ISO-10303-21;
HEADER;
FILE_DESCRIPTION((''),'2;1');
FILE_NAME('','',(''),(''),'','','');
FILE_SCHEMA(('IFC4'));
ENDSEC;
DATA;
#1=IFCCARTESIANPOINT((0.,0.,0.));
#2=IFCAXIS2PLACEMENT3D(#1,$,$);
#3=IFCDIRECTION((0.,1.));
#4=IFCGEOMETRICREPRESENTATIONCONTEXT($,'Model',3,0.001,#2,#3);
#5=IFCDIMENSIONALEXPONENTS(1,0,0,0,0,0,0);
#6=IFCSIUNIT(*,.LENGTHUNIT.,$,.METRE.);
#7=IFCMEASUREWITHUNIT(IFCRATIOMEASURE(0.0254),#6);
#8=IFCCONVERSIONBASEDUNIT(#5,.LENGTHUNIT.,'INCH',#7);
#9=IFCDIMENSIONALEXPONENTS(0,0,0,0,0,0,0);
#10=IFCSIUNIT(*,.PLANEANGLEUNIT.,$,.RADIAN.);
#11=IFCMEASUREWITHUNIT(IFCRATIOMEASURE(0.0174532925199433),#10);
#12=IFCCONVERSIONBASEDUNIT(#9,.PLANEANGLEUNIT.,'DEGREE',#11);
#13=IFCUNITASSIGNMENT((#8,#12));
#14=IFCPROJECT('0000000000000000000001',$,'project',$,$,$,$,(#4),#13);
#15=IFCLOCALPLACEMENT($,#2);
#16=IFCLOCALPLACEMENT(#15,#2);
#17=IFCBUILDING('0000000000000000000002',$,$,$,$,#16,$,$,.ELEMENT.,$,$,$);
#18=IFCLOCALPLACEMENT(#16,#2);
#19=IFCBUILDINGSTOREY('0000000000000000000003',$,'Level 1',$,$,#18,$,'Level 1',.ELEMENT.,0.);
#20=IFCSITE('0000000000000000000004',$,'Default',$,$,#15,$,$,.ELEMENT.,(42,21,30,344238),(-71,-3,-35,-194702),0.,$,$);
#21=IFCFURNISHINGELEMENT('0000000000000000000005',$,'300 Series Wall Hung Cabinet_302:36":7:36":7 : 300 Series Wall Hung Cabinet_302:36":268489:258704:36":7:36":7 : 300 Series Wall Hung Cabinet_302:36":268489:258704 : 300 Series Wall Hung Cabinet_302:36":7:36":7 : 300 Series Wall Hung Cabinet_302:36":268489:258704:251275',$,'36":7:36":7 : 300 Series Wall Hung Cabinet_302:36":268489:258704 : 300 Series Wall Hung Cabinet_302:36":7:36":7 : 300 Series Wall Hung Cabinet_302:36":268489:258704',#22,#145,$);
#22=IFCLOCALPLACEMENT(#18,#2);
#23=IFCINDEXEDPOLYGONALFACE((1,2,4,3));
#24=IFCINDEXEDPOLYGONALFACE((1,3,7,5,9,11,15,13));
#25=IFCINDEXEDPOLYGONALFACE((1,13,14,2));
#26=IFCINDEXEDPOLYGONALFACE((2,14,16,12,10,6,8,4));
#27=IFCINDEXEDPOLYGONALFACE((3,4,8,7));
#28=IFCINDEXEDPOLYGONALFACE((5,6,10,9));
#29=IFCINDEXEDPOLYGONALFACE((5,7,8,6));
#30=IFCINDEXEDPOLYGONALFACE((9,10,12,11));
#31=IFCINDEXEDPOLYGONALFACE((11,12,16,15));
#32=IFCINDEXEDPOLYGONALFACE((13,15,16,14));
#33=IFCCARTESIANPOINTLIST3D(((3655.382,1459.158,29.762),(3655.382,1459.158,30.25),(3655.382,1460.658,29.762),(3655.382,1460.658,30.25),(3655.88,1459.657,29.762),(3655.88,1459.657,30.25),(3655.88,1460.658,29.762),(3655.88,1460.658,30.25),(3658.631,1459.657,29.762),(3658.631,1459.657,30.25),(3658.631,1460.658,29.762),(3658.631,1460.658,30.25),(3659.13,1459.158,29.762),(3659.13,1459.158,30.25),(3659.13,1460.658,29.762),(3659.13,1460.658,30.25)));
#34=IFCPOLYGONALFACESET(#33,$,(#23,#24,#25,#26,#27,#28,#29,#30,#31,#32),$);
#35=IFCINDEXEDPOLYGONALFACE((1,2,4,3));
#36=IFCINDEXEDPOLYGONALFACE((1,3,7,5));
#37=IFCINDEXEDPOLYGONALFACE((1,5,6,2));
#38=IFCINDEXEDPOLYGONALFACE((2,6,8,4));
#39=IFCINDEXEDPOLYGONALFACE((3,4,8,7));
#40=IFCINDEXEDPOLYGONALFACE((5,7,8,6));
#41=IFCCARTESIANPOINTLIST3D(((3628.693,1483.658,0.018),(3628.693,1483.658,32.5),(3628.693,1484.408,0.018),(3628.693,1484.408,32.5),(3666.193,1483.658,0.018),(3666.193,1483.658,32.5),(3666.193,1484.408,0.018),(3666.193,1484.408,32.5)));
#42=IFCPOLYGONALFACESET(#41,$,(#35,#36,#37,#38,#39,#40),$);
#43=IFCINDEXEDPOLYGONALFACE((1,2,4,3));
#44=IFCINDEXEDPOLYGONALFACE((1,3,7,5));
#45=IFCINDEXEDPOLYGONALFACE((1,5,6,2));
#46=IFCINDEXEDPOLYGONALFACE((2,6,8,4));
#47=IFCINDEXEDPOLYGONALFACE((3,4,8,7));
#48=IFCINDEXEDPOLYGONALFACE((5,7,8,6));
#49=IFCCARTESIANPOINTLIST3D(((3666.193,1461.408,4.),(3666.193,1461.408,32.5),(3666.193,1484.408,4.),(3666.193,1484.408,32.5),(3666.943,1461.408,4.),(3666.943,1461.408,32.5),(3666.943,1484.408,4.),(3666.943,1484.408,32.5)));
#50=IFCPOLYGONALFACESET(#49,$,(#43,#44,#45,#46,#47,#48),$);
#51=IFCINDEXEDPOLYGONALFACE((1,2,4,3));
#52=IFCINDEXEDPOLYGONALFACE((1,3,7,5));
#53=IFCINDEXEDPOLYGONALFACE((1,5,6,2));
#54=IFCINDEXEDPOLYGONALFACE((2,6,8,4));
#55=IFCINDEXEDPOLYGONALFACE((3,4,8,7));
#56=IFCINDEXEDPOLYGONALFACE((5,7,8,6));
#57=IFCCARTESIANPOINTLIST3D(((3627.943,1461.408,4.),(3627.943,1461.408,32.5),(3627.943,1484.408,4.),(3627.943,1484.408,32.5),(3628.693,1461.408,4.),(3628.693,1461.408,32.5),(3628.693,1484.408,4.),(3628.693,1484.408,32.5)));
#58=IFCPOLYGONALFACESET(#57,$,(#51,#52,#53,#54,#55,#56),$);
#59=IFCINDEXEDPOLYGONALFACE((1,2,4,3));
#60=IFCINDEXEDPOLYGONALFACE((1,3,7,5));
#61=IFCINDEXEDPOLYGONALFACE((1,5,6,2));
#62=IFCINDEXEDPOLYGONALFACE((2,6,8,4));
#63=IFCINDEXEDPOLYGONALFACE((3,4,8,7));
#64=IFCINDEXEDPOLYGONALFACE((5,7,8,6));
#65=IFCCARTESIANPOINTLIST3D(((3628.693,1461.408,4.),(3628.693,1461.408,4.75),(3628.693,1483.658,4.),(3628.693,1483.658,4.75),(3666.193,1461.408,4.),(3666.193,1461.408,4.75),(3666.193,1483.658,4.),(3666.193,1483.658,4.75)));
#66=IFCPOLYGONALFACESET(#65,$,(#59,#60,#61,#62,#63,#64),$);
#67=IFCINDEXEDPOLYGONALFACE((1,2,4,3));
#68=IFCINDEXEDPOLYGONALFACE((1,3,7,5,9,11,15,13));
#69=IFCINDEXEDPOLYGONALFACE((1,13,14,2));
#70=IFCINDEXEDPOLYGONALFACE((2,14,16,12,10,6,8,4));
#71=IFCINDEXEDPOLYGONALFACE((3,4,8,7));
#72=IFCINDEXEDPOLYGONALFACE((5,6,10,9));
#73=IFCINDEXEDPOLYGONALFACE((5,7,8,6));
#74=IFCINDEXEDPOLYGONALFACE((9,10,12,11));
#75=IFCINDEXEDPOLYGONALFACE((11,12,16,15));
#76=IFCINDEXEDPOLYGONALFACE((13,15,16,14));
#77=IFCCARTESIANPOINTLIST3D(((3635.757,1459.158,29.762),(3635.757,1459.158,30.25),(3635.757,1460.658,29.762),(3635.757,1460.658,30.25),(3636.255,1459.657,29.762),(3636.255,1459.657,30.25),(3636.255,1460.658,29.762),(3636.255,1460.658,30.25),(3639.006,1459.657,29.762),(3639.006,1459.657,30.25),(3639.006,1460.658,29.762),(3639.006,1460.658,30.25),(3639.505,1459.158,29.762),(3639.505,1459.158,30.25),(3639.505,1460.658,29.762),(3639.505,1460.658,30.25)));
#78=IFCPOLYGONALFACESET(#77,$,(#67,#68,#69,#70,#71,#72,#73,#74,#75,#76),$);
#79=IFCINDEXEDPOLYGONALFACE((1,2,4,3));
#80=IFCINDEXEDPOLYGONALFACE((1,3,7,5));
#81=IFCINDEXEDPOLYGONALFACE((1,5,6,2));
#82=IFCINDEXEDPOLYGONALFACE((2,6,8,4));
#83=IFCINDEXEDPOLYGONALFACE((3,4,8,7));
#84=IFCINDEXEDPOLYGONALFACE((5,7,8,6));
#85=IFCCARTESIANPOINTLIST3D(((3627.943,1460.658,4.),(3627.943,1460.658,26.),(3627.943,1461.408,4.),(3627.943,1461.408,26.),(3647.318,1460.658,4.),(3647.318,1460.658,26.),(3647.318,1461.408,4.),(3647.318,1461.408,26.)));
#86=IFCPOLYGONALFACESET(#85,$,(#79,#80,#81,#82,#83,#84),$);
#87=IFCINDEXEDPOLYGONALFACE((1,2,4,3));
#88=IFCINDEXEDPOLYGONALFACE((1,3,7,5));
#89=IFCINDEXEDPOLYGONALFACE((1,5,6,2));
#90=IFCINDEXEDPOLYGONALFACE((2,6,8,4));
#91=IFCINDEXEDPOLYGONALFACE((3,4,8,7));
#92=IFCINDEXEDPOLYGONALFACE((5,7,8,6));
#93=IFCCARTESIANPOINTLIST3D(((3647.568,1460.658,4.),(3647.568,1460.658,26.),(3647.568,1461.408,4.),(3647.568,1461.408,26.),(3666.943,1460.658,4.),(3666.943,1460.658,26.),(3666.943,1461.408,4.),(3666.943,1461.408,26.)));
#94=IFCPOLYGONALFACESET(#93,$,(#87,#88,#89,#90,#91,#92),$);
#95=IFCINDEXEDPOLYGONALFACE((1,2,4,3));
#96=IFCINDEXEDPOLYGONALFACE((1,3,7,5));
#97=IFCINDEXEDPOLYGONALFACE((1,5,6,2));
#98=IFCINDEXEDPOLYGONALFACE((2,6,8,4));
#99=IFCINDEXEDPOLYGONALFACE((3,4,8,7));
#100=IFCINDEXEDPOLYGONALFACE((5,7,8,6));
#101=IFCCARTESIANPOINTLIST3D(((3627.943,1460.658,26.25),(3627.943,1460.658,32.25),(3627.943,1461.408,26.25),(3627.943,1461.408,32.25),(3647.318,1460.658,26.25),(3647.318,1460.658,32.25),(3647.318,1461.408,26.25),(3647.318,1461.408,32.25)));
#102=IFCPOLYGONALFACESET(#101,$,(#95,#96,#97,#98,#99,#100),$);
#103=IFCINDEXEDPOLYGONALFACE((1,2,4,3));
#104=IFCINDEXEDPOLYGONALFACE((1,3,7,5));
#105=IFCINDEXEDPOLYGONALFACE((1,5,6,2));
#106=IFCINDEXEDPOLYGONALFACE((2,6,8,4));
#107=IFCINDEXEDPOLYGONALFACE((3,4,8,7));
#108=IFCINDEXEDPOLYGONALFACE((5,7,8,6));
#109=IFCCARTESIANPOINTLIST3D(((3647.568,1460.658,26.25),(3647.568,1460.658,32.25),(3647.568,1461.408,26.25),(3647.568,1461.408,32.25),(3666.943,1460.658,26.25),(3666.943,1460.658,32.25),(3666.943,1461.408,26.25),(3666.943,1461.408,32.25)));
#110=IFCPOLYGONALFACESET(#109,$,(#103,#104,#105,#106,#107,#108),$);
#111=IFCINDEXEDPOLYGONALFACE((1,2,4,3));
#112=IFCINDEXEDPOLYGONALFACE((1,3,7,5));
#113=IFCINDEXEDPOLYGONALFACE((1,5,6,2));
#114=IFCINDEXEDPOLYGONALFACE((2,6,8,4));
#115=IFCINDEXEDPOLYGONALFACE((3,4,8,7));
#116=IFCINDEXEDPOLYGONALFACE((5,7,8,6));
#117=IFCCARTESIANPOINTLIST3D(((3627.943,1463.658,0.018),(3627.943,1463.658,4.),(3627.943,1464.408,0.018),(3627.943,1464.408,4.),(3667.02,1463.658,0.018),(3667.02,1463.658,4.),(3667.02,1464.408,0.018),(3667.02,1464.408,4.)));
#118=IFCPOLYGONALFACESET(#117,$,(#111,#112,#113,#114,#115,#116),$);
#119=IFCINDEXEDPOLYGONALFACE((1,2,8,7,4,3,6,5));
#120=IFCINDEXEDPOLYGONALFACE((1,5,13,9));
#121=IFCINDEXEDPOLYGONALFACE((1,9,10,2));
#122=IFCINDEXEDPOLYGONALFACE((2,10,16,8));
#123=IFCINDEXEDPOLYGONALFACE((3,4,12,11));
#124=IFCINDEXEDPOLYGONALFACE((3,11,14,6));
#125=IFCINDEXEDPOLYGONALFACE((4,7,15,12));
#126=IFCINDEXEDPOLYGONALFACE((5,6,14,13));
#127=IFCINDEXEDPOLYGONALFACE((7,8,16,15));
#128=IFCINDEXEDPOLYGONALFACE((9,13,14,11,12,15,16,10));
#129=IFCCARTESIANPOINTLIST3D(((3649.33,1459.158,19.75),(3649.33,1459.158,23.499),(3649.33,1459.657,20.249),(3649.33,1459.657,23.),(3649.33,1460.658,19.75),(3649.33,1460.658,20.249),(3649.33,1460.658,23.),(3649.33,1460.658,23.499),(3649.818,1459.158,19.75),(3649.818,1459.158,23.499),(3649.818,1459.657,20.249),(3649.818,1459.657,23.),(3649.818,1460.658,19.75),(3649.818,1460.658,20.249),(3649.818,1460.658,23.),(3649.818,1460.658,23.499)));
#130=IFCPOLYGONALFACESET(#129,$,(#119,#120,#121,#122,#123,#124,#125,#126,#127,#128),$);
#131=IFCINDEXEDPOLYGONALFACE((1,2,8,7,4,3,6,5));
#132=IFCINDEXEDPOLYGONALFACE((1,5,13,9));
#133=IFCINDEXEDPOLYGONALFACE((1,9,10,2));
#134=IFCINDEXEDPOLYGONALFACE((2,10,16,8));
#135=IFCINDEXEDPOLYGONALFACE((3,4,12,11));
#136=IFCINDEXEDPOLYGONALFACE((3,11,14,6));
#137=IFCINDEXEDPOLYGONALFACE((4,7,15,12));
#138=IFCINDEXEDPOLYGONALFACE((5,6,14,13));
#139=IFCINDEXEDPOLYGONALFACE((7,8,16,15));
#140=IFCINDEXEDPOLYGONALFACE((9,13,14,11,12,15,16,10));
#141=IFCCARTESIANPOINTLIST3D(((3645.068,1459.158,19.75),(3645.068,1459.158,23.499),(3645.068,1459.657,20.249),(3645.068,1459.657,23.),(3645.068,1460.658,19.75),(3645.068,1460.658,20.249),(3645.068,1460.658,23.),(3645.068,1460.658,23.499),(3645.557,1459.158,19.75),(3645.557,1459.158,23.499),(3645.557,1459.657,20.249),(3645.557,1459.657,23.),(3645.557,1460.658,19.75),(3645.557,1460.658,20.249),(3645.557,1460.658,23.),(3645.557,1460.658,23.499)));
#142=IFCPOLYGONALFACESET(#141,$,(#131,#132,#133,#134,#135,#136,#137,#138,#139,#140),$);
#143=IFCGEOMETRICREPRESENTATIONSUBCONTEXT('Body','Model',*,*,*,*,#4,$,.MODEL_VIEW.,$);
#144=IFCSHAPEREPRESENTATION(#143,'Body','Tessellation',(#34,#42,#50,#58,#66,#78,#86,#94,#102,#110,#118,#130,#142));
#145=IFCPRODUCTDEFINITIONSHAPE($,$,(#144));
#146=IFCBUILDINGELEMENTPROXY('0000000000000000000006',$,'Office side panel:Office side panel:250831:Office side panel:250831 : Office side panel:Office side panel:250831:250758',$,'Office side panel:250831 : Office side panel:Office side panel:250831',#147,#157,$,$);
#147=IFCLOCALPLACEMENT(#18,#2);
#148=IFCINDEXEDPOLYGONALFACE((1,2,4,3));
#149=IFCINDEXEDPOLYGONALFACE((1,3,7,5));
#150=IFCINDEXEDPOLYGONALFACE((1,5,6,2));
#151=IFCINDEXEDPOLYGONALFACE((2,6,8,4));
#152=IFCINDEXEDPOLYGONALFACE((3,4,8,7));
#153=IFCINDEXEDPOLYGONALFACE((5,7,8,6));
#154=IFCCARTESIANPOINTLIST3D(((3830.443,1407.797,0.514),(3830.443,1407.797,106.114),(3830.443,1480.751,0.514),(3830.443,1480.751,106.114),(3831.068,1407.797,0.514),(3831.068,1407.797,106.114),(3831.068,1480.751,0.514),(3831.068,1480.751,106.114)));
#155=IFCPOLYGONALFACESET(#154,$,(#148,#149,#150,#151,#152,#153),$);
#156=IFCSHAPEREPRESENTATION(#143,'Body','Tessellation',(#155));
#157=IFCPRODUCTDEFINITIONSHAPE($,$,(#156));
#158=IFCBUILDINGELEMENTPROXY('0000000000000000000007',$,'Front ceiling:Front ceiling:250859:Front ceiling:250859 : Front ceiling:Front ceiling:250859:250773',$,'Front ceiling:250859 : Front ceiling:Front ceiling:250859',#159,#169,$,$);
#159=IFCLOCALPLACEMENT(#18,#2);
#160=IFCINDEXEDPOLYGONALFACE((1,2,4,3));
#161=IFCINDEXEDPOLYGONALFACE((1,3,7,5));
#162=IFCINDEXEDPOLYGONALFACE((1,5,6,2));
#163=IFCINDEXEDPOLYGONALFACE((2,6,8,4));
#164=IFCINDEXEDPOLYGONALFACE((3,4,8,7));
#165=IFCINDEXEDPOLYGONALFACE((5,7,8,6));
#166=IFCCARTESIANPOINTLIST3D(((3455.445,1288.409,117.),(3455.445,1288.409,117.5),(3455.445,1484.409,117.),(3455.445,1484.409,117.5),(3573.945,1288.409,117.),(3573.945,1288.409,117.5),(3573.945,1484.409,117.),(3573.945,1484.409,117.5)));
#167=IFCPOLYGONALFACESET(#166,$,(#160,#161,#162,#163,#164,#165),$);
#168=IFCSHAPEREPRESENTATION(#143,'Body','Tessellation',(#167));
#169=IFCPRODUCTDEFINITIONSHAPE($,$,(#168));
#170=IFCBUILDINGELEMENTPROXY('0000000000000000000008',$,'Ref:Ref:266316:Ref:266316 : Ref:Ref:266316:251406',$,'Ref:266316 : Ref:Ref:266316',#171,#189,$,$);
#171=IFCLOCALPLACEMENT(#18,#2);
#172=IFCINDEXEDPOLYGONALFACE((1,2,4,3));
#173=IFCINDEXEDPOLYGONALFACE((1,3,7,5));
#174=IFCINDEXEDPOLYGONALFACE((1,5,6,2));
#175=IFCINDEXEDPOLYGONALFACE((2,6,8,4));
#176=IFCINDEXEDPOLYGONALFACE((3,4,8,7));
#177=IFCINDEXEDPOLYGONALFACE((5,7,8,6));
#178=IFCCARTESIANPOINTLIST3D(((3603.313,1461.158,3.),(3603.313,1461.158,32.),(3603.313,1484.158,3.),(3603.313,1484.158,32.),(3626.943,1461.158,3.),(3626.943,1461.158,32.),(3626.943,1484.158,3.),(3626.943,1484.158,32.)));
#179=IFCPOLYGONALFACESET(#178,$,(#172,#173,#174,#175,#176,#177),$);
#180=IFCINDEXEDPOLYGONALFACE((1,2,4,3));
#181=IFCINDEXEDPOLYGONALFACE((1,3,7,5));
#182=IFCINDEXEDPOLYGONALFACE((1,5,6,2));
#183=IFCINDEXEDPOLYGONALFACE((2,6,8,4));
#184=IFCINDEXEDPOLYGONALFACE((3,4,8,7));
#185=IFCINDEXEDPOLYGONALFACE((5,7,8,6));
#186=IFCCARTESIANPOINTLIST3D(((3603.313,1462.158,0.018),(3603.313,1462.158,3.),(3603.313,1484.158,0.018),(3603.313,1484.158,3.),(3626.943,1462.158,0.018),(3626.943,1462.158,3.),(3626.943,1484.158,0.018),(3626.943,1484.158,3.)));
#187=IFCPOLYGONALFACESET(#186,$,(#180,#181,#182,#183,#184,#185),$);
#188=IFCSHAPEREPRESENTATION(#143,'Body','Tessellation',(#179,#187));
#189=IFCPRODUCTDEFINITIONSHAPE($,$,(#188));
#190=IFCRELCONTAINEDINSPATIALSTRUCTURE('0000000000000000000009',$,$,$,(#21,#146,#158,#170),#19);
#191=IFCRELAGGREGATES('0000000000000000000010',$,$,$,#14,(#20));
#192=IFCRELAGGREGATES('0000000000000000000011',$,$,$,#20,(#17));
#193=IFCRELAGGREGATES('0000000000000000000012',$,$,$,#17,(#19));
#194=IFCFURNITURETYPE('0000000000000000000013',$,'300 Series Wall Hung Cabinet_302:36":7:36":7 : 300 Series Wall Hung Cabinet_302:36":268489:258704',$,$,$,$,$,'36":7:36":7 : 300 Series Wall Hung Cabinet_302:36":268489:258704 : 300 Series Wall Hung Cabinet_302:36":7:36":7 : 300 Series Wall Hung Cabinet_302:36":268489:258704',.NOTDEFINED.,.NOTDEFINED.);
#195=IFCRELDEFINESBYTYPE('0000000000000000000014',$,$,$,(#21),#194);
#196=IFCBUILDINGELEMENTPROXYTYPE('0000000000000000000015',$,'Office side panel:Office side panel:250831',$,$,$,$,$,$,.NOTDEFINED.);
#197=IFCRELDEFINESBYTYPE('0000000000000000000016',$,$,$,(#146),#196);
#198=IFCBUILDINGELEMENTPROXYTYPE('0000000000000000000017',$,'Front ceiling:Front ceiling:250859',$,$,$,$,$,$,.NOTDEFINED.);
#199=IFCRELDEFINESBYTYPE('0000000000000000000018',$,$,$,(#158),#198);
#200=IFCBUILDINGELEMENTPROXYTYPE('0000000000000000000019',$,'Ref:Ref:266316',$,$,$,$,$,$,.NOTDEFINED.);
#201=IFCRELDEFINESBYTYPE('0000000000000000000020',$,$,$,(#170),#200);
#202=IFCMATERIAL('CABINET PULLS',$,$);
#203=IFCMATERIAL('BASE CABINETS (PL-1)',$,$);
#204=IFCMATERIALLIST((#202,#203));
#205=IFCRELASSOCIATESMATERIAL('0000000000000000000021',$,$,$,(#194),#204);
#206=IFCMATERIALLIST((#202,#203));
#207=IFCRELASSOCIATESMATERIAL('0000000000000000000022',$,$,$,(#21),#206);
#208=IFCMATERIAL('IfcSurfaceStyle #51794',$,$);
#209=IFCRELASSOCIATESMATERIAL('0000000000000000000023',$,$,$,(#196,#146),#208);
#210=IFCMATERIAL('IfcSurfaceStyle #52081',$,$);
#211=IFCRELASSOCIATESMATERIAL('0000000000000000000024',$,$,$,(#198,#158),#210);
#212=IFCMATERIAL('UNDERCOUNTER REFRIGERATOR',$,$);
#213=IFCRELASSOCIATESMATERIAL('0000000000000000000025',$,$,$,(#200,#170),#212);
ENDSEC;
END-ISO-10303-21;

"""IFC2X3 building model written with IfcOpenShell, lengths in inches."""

from ifc_helpers import new_model, entity, si_unit, converted_unit, direction, frame, frame_2d, origin, origin_2d_with_axis, place, context, subcontext, project, spatial, polyline, rectangle, outline, extrude, source, transform, mapped, material, material_list, type_object, type_shapes, element, save


model = new_model("IFC2X3")

# Units and contexts
model_context = context("Model", 3, precision=0.001, world=origin(), true_north=direction((0.0, 1.0)))
body_context = subcontext(model_context, "Body", "Model", "MODEL_VIEW")
ifc_project = project(units=[converted_unit("LENGTHUNIT", "INCH", entity("IfcRatioMeasure", 0.0254), si_unit("LENGTHUNIT", "METRE"), dimensions=[1, 0, 0, 0, 0, 0, 0]), converted_unit("PLANEANGLEUNIT", "DEGREE", entity("IfcRatioMeasure", 0.0174532925199433), si_unit("PLANEANGLEUNIT", "RADIAN"), dimensions=[0, 0, 0, 0, 0, 0, 0])], contexts=[model_context])

# Site, building, storey
site_placement = place(None, origin())
site = spatial("IfcSite", under=ifc_project, at=site_placement, Name="Default", CompositionType="ELEMENT", RefLatitude=(42, 21, 30, 344238), RefLongitude=(-71, -3, -35, -194702), RefElevation=0.0)
building_placement = place(site_placement, origin())
building = spatial("IfcBuilding", under=site, at=building_placement, CompositionType="ELEMENT")
storey_placement = place(building_placement, origin())
storey = spatial("IfcBuildingStorey", under=building, at=storey_placement, Name="Level 1", LongName="Level 1", CompositionType="ELEMENT", Elevation=0.0)

# Furnishing element
ifc_material_1 = material(Name="CABINET PULLS")
ifc_material_2 = material(Name="BASE CABINETS (PL-1)")
ifc_material_list_1 = material_list([ifc_material_1, ifc_material_2])
ifc_material_list_2 = material_list([ifc_material_1, ifc_material_2])
furniture_type_1 = type_object("IfcFurnitureType", Name="300 Series Wall Hung Cabinet_302:36\":7:36\":7 : 300 Series Wall Hung Cabinet_302:36\":268489:258704", ElementType="36\":7:36\":7 : 300 Series Wall Hung Cabinet_302:36\":268489:258704 : 300 Series Wall Hung Cabinet_302:36\":7:36\":7 : 300 Series Wall Hung Cabinet_302:36\":268489:258704", AssemblyPlace="NOTDEFINED", material=ifc_material_list_2)
shared_shape_1 = source(origin(), body_context, "Body", "SweptSolid", [
    extrude(outline(polyline([(-0.376, 1.375), (0.625, 1.375), (0.625, 1.874), (-0.874, 1.874), (-0.874, -1.874), (0.625, -1.874), (0.625, -1.375), (-0.376, -1.375), (-0.376, 1.375)])), frame((3657.256, 1460.033, 29.762), z_axis=(0.0, 0.0, 1.0), x_axis=(0.0, 1.0, 0.0)), (0.0, 0.0, 1.0), 0.488),
    extrude(rectangle(XDim=0.75, YDim=37.5, at=origin_2d_with_axis()), frame((3647.443, 1484.033, 0.018), z_axis=(0.0, 0.0, 1.0), x_axis=(0.0, 1.0, 0.0)), (0.0, 0.0, 1.0), 32.482),
    extrude(rectangle(XDim=0.75, YDim=23.0, at=frame_2d((0.0, 0.0), x_axis=(1.0, 0.0))), frame((3666.568, 1472.908, 4.0)), (0.0, 0.0, 1.0), 28.5),
    extrude(rectangle(XDim=0.75, YDim=23.0, at=frame_2d((0.0, 0.0), x_axis=(1.0, 0.0))), frame((3628.318, 1472.908, 4.0)), (0.0, 0.0, 1.0), 28.5),
    extrude(rectangle(XDim=37.5, YDim=22.25, at=frame_2d((0.0, 0.0), x_axis=(1.0, 0.0))), frame((3647.443, 1472.533, 4.0), z_axis=(0.0, 0.0, 1.0), x_axis=(-1.0, 0.0, 0.0)), (0.0, 0.0, 1.0), 0.75),
    extrude(outline(polyline([(-0.376, 1.375), (0.625, 1.375), (0.625, 1.874), (-0.874, 1.874), (-0.874, -1.874), (0.625, -1.874), (0.625, -1.375), (-0.376, -1.375), (-0.376, 1.375)])), frame((3637.631, 1460.033, 29.762), z_axis=(0.0, 0.0, 1.0), x_axis=(0.0, 1.0, 0.0)), (0.0, 0.0, 1.0), 0.488),
    extrude(rectangle(XDim=19.375, YDim=0.75, at=frame_2d((0.0, 0.0), x_axis=(1.0, 0.0))), frame((3637.631, 1461.033, 4.0), z_axis=(0.0, 0.0, 1.0), x_axis=(-1.0, 0.0, 0.0)), (0.0, 0.0, 1.0), 22.0),
    extrude(rectangle(XDim=19.375, YDim=0.75, at=frame_2d((0.0, 0.0), x_axis=(1.0, 0.0))), frame((3657.256, 1461.033, 4.0), z_axis=(0.0, 0.0, 1.0), x_axis=(-1.0, 0.0, 0.0)), (0.0, 0.0, 1.0), 22.0),
    extrude(rectangle(XDim=19.375, YDim=0.75, at=frame_2d((0.0, 0.0), x_axis=(1.0, 0.0))), frame((3637.631, 1461.033, 26.25), z_axis=(0.0, 0.0, 1.0), x_axis=(-1.0, 0.0, 0.0)), (0.0, 0.0, 1.0), 6.0),
    extrude(rectangle(XDim=19.375, YDim=0.75, at=frame_2d((0.0, 0.0), x_axis=(1.0, 0.0))), frame((3657.256, 1461.033, 26.25), z_axis=(0.0, 0.0, 1.0), x_axis=(-1.0, 0.0, 0.0)), (0.0, 0.0, 1.0), 6.0),
    extrude(rectangle(XDim=0.75, YDim=39.077, at=origin_2d_with_axis()), frame((3647.482, 1464.033, 0.018), z_axis=(0.0, 0.0, 1.0), x_axis=(0.0, 1.0, 0.0)), (0.0, 0.0, 1.0), 3.982),
    extrude(outline(polyline([(-0.376, 1.375), (0.625, 1.375), (0.625, 1.874), (-0.874, 1.874), (-0.874, -1.874), (0.625, -1.874), (0.625, -1.375), (-0.376, -1.375), (-0.376, 1.375)])), frame((3649.33, 1460.033, 21.625), z_axis=(1.0, 0.0, 0.0), x_axis=(0.0, 1.0, 0.0)), (0.0, 0.0, 1.0), 0.488),
    extrude(outline(polyline([(-0.376, 1.375), (0.625, 1.375), (0.625, 1.874), (-0.874, 1.874), (-0.874, -1.874), (0.625, -1.874), (0.625, -1.375), (-0.376, -1.375), (-0.376, 1.375)])), frame((3645.068, 1460.033, 21.625), z_axis=(1.0, 0.0, 0.0), x_axis=(0.0, 1.0, 0.0)), (0.0, 0.0, 1.0), 0.488),
])
type_shapes(furniture_type_1, [shared_shape_1])
furnishing_1_placement = place(storey_placement, origin())
element("IfcFurnishingElement", 1, at=furnishing_1_placement, inside=storey, type_object=furniture_type_1, material=ifc_material_list_1, Name="300 Series Wall Hung Cabinet_302:36\":7:36\":7 : 300 Series Wall Hung Cabinet_302:36\":268489:258704:36\":7:36\":7 : 300 Series Wall Hung Cabinet_302:36\":268489:258704 : 300 Series Wall Hung Cabinet_302:36\":7:36\":7 : 300 Series Wall Hung Cabinet_302:36\":268489:258704:251275", ObjectType="36\":7:36\":7 : 300 Series Wall Hung Cabinet_302:36\":268489:258704 : 300 Series Wall Hung Cabinet_302:36\":7:36\":7 : 300 Series Wall Hung Cabinet_302:36\":268489:258704", context=body_context, shape_type="MappedRepresentation", body=[
    mapped(shared_shape_1, transform((0.0, 0.0, 0.0), scale=1.0)),
])

# Building element proxies
ifc_material_3 = material(Name="IfcSurfaceStyle #51794")
building_element_proxy_type_1 = type_object("IfcBuildingElementProxyType", Name="Office side panel:Office side panel:250831", PredefinedType="NOTDEFINED", material=ifc_material_3)
shared_shape_2 = source(origin(), body_context, "Body", "SweptSolid", [
    extrude(rectangle(XDim=72.954, YDim=0.625, at=origin_2d_with_axis()), frame((3830.756, 1444.274, 0.514), z_axis=(0.0, 0.0, 1.0), x_axis=(0.0, 1.0, 0.0)), (0.0, 0.0, 1.0), 105.6),
])
type_shapes(building_element_proxy_type_1, [shared_shape_2])
proxy_1_placement = place(storey_placement, origin())
element("IfcBuildingElementProxy", 2, at=proxy_1_placement, inside=storey, type_object=building_element_proxy_type_1, material=ifc_material_3, Name="Office side panel:Office side panel:250831:Office side panel:250831 : Office side panel:Office side panel:250831:250758", ObjectType="Office side panel:250831 : Office side panel:Office side panel:250831", context=body_context, shape_type="MappedRepresentation", body=[
    mapped(shared_shape_2, transform((0.0, 0.0, 0.0), scale=1.0)),
])
ifc_material_4 = material(Name="IfcSurfaceStyle #52081")
building_element_proxy_type_2 = type_object("IfcBuildingElementProxyType", Name="Front ceiling:Front ceiling:250859", PredefinedType="NOTDEFINED", material=ifc_material_4)
shared_shape_3 = source(origin(), body_context, "Body", "SweptSolid", [
    extrude(rectangle(XDim=196.0, YDim=118.5, at=frame_2d((0.0, 0.0), x_axis=(1.0, 0.0))), frame((3514.695, 1386.409, 117.0), z_axis=(0.0, 0.0, 1.0), x_axis=(0.0, 1.0, 0.0)), (0.0, 0.0, 1.0), 0.5),
])
type_shapes(building_element_proxy_type_2, [shared_shape_3])
proxy_2_placement = place(storey_placement, origin())
element("IfcBuildingElementProxy", 3, at=proxy_2_placement, inside=storey, type_object=building_element_proxy_type_2, material=ifc_material_4, Name="Front ceiling:Front ceiling:250859:Front ceiling:250859 : Front ceiling:Front ceiling:250859:250773", ObjectType="Front ceiling:250859 : Front ceiling:Front ceiling:250859", context=body_context, shape_type="MappedRepresentation", body=[
    mapped(shared_shape_3, transform((0.0, 0.0, 0.0), scale=1.0)),
])
ifc_material_5 = material(Name="UNDERCOUNTER REFRIGERATOR")
building_element_proxy_type_3 = type_object("IfcBuildingElementProxyType", Name="Ref:Ref:266316", PredefinedType="NOTDEFINED", material=ifc_material_5)
shared_shape_4 = source(origin(), body_context, "Body", "SweptSolid", [
    extrude(rectangle(XDim=23.63, YDim=23.0, at=frame_2d((0.0, 0.0), x_axis=(1.0, 0.0))), frame((3615.128, 1472.658, 3.0), z_axis=(0.0, 0.0, 1.0), x_axis=(-1.0, 0.0, 0.0)), (0.0, 0.0, 1.0), 29.0),
    extrude(rectangle(XDim=23.63, YDim=22.0, at=frame_2d((0.0, 0.0), x_axis=(1.0, 0.0))), frame((3615.128, 1473.158, 0.018), z_axis=(0.0, 0.0, 1.0), x_axis=(-1.0, 0.0, 0.0)), (0.0, 0.0, 1.0), 2.982),
])
type_shapes(building_element_proxy_type_3, [shared_shape_4])
proxy_3_placement = place(storey_placement, origin())
element("IfcBuildingElementProxy", 4, at=proxy_3_placement, inside=storey, type_object=building_element_proxy_type_3, material=ifc_material_5, Name="Ref:Ref:266316:Ref:266316 : Ref:Ref:266316:251406", ObjectType="Ref:266316 : Ref:Ref:266316", context=body_context, shape_type="MappedRepresentation", body=[
    mapped(shared_shape_4, transform((0.0, 0.0, 0.0), scale=1.0)),
])

save(model, "model.ifc")
